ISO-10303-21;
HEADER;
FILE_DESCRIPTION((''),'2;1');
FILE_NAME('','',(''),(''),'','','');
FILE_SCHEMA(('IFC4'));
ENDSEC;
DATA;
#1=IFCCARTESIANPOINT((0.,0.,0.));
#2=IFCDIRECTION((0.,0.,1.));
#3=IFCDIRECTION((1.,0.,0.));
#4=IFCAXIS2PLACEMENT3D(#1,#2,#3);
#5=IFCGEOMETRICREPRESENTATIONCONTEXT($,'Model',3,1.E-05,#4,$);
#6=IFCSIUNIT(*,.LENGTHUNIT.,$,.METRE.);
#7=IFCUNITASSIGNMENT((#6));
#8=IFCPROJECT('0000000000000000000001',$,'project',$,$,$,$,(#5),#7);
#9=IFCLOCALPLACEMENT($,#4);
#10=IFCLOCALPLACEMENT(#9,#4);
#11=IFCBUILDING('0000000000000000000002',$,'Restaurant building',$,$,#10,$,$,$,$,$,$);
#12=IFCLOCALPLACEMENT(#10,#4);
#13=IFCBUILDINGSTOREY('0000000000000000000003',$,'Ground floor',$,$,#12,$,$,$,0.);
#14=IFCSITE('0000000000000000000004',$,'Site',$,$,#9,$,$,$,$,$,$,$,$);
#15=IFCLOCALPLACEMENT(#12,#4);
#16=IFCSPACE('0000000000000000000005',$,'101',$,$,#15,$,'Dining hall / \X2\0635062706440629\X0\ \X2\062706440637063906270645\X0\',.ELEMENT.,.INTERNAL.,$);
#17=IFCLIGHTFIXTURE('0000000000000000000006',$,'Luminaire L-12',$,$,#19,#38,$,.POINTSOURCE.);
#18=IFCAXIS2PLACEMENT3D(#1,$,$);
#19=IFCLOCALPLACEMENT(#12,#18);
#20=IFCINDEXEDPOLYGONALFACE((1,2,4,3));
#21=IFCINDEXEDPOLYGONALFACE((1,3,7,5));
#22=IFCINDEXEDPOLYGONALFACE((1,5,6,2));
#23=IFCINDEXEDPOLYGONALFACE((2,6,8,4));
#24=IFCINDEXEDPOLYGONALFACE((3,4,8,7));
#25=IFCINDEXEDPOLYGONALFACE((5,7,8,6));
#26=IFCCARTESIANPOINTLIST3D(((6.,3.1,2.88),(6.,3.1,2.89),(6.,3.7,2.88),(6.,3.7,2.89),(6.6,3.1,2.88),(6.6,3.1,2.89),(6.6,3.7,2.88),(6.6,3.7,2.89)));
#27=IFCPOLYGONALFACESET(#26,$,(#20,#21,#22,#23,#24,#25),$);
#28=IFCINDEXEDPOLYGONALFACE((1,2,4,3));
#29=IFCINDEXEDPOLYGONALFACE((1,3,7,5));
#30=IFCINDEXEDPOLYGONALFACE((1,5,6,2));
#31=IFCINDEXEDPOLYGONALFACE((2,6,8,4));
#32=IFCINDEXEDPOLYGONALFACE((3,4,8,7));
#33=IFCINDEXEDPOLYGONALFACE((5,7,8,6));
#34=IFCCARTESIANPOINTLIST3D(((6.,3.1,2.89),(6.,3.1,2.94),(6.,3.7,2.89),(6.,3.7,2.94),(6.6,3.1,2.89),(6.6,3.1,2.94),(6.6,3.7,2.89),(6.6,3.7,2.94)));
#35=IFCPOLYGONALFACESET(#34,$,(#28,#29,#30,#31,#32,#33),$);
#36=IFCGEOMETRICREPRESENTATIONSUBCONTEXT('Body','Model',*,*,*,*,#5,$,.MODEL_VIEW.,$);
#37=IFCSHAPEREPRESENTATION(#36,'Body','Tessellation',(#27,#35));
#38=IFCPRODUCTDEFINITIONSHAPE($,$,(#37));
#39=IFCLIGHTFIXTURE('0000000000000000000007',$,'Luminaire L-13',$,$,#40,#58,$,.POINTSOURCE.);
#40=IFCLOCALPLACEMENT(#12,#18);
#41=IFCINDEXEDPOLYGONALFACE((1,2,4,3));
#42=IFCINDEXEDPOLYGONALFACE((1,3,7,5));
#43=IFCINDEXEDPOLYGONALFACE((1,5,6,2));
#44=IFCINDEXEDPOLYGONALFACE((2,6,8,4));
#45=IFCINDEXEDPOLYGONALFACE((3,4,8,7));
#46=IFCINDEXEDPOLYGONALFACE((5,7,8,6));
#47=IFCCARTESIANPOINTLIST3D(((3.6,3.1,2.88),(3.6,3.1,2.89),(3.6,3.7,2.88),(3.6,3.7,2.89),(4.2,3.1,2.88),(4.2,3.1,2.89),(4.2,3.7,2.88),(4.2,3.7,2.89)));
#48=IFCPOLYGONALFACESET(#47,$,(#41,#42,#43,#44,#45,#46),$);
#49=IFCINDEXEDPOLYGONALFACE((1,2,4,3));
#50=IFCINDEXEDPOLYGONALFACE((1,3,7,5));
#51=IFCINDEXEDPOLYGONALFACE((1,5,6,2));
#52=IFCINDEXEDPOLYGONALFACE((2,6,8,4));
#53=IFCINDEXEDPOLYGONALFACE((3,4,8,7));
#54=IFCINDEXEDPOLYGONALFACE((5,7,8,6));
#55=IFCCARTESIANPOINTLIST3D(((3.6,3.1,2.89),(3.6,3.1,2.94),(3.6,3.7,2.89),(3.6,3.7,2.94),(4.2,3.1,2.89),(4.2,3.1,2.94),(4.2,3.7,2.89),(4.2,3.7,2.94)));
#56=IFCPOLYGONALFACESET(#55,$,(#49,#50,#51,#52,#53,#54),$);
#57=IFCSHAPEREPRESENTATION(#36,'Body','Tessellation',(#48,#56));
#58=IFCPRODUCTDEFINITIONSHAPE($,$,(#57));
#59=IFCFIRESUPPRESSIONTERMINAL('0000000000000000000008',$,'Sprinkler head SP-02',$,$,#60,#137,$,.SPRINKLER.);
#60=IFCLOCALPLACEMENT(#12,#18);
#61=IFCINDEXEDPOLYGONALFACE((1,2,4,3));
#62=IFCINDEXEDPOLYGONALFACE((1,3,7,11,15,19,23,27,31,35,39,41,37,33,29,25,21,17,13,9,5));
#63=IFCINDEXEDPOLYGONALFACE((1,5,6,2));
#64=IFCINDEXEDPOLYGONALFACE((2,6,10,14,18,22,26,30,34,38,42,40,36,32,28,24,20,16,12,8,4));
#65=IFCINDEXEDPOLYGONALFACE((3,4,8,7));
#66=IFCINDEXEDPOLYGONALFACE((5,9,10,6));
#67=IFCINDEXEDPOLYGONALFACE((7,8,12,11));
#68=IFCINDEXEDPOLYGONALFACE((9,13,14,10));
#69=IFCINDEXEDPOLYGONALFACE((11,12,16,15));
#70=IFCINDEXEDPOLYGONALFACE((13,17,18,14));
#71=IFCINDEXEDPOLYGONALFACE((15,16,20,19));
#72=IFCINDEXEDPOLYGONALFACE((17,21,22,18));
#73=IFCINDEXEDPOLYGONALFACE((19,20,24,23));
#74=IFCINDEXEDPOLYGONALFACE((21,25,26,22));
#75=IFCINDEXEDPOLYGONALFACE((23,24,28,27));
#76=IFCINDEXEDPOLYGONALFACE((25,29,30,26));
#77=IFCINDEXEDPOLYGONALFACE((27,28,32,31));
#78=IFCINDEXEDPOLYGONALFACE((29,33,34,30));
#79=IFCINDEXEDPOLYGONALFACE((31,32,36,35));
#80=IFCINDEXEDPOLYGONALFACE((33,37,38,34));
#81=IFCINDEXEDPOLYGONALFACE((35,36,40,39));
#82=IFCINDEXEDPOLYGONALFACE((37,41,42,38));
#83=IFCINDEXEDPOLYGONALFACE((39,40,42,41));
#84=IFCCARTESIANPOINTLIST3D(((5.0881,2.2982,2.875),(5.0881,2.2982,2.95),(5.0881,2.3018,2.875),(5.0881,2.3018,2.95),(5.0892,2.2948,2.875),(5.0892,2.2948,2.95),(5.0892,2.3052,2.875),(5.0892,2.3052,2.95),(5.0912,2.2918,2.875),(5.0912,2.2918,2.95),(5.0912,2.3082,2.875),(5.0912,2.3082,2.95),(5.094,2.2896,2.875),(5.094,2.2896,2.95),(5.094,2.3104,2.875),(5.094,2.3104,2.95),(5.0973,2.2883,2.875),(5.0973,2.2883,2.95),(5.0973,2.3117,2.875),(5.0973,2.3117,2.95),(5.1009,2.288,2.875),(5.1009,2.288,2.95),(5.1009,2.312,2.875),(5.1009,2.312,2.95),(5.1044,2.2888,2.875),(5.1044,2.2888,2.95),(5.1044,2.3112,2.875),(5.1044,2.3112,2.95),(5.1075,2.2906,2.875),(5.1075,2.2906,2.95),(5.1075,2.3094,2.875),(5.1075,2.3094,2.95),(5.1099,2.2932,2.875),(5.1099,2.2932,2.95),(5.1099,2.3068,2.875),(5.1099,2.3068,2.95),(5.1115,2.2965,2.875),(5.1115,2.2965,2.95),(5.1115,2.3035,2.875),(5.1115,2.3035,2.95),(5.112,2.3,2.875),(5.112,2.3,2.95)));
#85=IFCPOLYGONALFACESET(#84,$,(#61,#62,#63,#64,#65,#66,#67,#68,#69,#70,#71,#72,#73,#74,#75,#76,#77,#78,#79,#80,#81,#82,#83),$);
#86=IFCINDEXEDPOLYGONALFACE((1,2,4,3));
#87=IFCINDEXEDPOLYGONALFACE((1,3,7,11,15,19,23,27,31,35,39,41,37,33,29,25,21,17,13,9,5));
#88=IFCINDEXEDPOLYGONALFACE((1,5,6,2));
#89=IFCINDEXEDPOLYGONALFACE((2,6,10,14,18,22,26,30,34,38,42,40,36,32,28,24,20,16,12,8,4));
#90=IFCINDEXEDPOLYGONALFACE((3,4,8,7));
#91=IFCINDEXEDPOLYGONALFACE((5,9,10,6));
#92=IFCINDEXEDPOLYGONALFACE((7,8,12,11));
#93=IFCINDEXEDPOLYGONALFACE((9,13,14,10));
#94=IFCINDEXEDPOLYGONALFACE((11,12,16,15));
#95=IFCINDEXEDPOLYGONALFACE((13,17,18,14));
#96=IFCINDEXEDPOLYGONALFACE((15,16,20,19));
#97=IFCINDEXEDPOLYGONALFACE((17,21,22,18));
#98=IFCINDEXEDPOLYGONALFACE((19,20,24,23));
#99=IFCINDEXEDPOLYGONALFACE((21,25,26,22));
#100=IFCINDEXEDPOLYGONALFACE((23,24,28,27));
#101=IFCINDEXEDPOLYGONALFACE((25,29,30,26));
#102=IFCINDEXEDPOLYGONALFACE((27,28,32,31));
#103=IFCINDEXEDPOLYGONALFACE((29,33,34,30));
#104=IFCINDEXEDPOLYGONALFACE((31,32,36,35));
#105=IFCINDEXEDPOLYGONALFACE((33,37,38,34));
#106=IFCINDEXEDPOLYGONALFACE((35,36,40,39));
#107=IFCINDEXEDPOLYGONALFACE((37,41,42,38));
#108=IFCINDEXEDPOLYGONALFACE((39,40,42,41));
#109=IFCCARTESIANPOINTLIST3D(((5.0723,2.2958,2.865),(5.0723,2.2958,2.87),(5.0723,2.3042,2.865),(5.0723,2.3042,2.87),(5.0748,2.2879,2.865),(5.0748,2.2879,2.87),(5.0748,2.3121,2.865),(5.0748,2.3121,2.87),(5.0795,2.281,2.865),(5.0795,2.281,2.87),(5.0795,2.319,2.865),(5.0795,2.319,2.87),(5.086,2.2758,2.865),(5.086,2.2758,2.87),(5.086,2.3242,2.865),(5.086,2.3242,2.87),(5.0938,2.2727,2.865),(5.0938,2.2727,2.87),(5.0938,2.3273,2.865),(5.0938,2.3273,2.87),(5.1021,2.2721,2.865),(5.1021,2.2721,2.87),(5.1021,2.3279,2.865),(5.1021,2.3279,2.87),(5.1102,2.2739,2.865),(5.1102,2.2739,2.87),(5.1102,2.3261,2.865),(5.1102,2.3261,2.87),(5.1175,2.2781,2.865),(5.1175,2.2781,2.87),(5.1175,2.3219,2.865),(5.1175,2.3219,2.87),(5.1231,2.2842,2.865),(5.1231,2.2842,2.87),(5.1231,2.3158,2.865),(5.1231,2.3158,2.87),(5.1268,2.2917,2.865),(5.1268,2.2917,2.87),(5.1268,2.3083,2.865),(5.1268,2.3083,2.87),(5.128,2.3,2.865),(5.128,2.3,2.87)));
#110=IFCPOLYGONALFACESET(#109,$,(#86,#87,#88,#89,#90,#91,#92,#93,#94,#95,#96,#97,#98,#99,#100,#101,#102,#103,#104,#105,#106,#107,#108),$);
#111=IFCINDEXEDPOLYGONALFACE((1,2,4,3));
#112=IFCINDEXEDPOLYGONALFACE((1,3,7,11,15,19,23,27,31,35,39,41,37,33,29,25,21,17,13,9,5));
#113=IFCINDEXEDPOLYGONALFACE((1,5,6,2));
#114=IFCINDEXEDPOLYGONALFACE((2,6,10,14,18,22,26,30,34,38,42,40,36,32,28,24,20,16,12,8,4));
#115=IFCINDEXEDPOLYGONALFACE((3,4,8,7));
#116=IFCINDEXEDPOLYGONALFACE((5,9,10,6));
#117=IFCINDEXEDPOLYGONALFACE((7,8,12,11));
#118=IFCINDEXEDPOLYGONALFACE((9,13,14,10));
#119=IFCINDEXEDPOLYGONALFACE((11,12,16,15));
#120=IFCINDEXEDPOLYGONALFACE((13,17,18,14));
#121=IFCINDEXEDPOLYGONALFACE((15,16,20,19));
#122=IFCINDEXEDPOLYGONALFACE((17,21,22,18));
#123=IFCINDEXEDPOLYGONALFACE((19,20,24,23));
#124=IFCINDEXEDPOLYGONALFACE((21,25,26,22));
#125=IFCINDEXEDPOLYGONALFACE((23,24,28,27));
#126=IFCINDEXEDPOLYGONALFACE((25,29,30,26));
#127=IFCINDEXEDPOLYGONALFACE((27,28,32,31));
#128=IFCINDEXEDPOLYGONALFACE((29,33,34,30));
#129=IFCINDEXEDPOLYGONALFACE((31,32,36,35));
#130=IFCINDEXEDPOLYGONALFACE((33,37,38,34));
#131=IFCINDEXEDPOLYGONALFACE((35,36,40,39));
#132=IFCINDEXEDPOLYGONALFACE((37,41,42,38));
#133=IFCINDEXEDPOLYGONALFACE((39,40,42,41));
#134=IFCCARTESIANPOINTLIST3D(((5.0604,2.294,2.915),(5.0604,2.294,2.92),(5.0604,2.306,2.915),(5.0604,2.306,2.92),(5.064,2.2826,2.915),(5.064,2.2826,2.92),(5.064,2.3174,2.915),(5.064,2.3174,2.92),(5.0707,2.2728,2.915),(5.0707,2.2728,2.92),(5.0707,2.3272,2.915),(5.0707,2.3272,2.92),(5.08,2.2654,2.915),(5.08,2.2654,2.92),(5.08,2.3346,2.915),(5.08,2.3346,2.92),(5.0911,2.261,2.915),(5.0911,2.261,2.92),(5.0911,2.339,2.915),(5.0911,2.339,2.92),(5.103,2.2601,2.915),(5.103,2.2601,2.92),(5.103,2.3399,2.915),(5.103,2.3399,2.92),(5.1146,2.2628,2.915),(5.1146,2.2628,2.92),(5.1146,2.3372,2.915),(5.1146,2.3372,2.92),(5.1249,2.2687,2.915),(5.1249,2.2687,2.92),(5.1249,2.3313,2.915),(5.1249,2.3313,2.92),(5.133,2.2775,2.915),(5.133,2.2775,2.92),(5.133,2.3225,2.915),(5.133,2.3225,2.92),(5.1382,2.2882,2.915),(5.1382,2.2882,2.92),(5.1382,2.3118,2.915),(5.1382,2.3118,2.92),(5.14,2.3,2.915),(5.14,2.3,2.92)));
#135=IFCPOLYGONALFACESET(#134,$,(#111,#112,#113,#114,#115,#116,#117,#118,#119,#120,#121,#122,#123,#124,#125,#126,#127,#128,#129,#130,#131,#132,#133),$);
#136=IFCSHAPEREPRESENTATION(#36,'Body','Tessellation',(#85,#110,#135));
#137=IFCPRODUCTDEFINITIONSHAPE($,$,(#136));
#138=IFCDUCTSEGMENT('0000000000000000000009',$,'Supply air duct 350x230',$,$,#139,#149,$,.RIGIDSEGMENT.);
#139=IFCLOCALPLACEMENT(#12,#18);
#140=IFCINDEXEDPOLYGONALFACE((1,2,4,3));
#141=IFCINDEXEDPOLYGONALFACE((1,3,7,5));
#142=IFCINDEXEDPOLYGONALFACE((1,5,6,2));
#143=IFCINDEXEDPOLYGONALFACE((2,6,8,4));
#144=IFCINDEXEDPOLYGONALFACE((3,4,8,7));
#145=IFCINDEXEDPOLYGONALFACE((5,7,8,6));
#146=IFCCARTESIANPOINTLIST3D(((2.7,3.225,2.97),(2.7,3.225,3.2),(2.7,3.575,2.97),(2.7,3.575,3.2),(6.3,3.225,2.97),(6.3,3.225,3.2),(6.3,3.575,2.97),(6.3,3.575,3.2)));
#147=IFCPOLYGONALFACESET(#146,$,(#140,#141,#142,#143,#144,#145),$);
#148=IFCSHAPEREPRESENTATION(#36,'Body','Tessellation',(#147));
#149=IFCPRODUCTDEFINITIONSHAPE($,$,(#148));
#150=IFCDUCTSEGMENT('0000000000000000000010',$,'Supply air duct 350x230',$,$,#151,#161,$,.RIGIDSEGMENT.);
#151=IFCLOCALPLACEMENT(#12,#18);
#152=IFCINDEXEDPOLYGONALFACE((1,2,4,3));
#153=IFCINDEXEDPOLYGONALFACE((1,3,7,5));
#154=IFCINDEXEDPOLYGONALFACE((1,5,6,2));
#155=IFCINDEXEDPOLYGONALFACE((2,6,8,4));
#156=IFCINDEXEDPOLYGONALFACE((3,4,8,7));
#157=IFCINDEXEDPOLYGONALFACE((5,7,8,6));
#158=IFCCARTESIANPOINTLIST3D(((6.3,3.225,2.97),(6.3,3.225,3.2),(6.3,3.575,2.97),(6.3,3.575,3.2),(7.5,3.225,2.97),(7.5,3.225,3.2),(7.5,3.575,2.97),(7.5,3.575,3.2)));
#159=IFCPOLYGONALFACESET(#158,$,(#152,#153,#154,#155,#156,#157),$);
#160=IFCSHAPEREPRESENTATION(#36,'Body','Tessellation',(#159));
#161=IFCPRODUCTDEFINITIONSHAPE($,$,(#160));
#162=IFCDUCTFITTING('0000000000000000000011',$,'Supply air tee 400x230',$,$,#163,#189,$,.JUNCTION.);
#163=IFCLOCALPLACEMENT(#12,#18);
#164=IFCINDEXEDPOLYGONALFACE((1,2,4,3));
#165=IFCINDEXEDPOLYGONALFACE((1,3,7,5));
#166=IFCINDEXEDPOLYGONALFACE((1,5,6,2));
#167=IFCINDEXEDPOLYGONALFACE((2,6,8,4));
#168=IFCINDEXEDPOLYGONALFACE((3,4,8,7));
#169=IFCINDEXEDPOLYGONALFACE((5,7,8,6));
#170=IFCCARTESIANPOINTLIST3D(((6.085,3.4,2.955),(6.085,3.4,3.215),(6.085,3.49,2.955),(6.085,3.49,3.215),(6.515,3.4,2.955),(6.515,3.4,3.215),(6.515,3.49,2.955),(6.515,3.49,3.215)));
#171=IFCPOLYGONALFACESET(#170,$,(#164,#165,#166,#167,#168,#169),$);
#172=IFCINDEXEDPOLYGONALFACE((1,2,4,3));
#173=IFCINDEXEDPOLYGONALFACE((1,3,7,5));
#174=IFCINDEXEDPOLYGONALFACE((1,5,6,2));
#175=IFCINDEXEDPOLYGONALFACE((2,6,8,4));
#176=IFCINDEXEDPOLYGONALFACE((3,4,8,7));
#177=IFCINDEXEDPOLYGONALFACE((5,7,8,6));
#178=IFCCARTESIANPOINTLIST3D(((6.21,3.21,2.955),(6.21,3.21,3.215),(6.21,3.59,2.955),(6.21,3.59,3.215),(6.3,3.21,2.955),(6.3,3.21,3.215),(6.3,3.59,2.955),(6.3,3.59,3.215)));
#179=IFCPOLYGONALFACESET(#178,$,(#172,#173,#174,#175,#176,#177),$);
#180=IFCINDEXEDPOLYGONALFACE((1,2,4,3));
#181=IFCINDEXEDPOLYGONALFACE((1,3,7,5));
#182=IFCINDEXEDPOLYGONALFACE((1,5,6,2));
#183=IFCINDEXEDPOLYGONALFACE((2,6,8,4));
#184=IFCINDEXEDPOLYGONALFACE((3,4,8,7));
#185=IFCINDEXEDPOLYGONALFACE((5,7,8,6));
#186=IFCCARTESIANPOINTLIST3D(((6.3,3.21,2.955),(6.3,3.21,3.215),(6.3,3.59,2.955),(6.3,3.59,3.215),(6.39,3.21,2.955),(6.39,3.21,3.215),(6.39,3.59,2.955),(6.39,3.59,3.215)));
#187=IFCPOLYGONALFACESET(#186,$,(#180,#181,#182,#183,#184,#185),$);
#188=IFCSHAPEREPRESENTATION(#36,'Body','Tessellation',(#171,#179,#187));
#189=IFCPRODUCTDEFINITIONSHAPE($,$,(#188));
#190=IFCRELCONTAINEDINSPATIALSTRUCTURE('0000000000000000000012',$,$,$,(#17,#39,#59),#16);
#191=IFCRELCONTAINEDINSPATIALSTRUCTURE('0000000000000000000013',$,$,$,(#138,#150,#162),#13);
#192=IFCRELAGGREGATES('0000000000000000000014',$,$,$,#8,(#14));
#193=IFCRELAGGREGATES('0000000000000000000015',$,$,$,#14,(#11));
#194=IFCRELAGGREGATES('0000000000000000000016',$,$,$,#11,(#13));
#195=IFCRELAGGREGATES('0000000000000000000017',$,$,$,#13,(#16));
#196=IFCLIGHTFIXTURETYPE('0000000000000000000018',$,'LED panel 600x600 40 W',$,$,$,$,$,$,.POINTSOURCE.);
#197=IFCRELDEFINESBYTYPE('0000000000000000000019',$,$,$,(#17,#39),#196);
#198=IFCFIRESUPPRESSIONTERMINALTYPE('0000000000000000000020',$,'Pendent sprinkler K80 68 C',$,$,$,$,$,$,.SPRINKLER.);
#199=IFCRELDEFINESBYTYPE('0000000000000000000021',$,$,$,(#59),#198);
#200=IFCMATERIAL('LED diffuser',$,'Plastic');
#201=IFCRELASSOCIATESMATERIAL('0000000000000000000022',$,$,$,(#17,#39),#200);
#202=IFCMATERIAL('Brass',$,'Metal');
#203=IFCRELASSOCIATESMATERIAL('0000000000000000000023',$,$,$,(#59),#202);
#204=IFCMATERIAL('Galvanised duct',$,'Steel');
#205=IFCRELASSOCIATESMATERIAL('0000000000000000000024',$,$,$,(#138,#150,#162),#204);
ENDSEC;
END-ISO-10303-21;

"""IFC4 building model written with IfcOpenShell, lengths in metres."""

from ifc_helpers import new_model, si_unit, frame, origin, origin_with_axes, origin_2d, place, context, subcontext, project, spatial, rectangle, circle, extrude, source, transform, mapped, material, type_object, type_shapes, element, save


model = new_model("IFC4")

# Units and contexts
model_context = context("Model", 3, precision=1e-05, world=origin_with_axes())
body_context = subcontext(model_context, "Body", "Model", "MODEL_VIEW")
ifc_project = project(units=[si_unit("LENGTHUNIT", "METRE")], contexts=[model_context])

# Site, building, storey, space
site_placement = place(None, origin_with_axes())
site = spatial("IfcSite", under=ifc_project, at=site_placement, Name="Site")
building_placement = place(site_placement, origin_with_axes())
building = spatial("IfcBuilding", under=site, at=building_placement, Name="Restaurant building")
storey_placement = place(building_placement, origin_with_axes())
storey = spatial("IfcBuildingStorey", under=building, at=storey_placement, Name="Ground floor", Elevation=0.0)
space_placement = place(storey_placement, origin_with_axes())
space = spatial("IfcSpace", under=storey, at=space_placement, Name="101", LongName="Dining hall / صالة الطعام", CompositionType="ELEMENT", PredefinedType="INTERNAL")

# Light fixtures
ifc_material_1 = material(Name="LED diffuser", Category="Plastic")
light_fixture_type = type_object("IfcLightFixtureType", Name="LED panel 600x600 40 W", PredefinedType="POINTSOURCE")
shared_shape_1 = source(origin(), body_context, "Body", "SweptSolid", [
    extrude(rectangle(XDim=0.6, YDim=0.6, at=origin_2d()), frame((0.0, 0.0, -0.06)), (0.0, 0.0, 1.0), 0.01),
    extrude(rectangle(XDim=0.6, YDim=0.6, at=origin_2d()), frame((0.0, 0.0, -0.05)), (0.0, 0.0, 1.0), 0.05),
])
type_shapes(light_fixture_type, [shared_shape_1])
for number, where, name in (
    (1, (6.3, 3.4, 2.94), "Luminaire L-12"),
    (2, (3.9, 3.4, 2.94), "Luminaire L-13"),
):
    element("IfcLightFixture", number, at=place(storey_placement, frame(where)), inside=space, type_object=light_fixture_type, material=ifc_material_1, Name=name, PredefinedType="POINTSOURCE", context=body_context, shape_type="MappedRepresentation", body=[
        mapped(shared_shape_1, transform((0.0, 0.0, 0.0))),
    ])

# Fire suppression terminal
ifc_material_2 = material(Name="Brass", Category="Metal")
fire_suppression_terminal_type = type_object("IfcFireSuppressionTerminalType", Name="Pendent sprinkler K80 68 C", PredefinedType="SPRINKLER")
shared_shape_2 = source(origin(), body_context, "Body", "SweptSolid", [
    extrude(circle(Radius=0.012, at=origin_2d()), frame((0.0, 0.0, -0.075)), (0.0, 0.0, 1.0), 0.075),
    extrude(circle(Radius=0.028, at=origin_2d()), frame((0.0, 0.0, -0.085)), (0.0, 0.0, 1.0), 0.005),
    extrude(circle(Radius=0.04, at=origin_2d()), frame((0.0, 0.0, -0.035)), (0.0, 0.0, 1.0), 0.005),
])
type_shapes(fire_suppression_terminal_type, [shared_shape_2])
fire_suppression_terminal_placement = place(storey_placement, frame((5.1, 2.3, 2.95)))
element("IfcFireSuppressionTerminal", 3, at=fire_suppression_terminal_placement, inside=space, type_object=fire_suppression_terminal_type, material=ifc_material_2, Name="Sprinkler head SP-02", PredefinedType="SPRINKLER", context=body_context, shape_type="MappedRepresentation", body=[
    mapped(shared_shape_2, transform((0.0, 0.0, 0.0))),
])

# Duct segments
ifc_material_3 = material(Name="Galvanised duct", Category="Steel")
duct_segment_1_placement = place(storey_placement, frame((6.3, 3.4, 3.085)))
element("IfcDuctSegment", 4, at=duct_segment_1_placement, inside=storey, material=ifc_material_3, Name="Supply air duct 350x230", PredefinedType="RIGIDSEGMENT", context=body_context, shape_type="SweptSolid", body=[
    extrude(rectangle(XDim=0.35, YDim=0.23, at=origin_2d()), frame((0.0, 0.0, 0.0), z_axis=(-1.0, 0.0, 0.0), x_axis=(0.0, -1.0, 0.0)), (0.0, 0.0, 1.0), 3.6),
])
duct_segment_2_placement = place(storey_placement, frame((6.3, 3.4, 3.085)))
element("IfcDuctSegment", 5, at=duct_segment_2_placement, inside=storey, material=ifc_material_3, Name="Supply air duct 350x230", PredefinedType="RIGIDSEGMENT", context=body_context, shape_type="SweptSolid", body=[
    extrude(rectangle(XDim=0.35, YDim=0.23, at=origin_2d()), frame((0.0, 0.0, 0.0), z_axis=(1.0, 0.0, 0.0), x_axis=(0.0, 1.0, 0.0)), (0.0, 0.0, 1.0), 1.2),
])

# Duct fitting
duct_fitting_placement = place(storey_placement, frame((6.3, 3.4, 3.085)))
element("IfcDuctFitting", 6, at=duct_fitting_placement, inside=storey, material=ifc_material_3, Name="Supply air tee 400x230", PredefinedType="JUNCTION", context=body_context, shape_type="SweptSolid", body=[
    extrude(rectangle(XDim=0.43, YDim=0.26, at=origin_2d()), frame((0.0, 0.0, 0.0), z_axis=(0.0, 1.0, 0.0), x_axis=(-1.0, 0.0, 0.0)), (0.0, 0.0, 1.0), 0.09),
    extrude(rectangle(XDim=0.38, YDim=0.26, at=origin_2d()), frame((0.0, 0.0, 0.0), z_axis=(-1.0, 0.0, 0.0), x_axis=(0.0, -1.0, 0.0)), (0.0, 0.0, 1.0), 0.09),
    extrude(rectangle(XDim=0.38, YDim=0.26, at=origin_2d()), frame((0.0, 0.0, 0.0), z_axis=(1.0, 0.0, 0.0), x_axis=(0.0, 1.0, 0.0)), (0.0, 0.0, 1.0), 0.09),
])

save(model, "model.ifc")
